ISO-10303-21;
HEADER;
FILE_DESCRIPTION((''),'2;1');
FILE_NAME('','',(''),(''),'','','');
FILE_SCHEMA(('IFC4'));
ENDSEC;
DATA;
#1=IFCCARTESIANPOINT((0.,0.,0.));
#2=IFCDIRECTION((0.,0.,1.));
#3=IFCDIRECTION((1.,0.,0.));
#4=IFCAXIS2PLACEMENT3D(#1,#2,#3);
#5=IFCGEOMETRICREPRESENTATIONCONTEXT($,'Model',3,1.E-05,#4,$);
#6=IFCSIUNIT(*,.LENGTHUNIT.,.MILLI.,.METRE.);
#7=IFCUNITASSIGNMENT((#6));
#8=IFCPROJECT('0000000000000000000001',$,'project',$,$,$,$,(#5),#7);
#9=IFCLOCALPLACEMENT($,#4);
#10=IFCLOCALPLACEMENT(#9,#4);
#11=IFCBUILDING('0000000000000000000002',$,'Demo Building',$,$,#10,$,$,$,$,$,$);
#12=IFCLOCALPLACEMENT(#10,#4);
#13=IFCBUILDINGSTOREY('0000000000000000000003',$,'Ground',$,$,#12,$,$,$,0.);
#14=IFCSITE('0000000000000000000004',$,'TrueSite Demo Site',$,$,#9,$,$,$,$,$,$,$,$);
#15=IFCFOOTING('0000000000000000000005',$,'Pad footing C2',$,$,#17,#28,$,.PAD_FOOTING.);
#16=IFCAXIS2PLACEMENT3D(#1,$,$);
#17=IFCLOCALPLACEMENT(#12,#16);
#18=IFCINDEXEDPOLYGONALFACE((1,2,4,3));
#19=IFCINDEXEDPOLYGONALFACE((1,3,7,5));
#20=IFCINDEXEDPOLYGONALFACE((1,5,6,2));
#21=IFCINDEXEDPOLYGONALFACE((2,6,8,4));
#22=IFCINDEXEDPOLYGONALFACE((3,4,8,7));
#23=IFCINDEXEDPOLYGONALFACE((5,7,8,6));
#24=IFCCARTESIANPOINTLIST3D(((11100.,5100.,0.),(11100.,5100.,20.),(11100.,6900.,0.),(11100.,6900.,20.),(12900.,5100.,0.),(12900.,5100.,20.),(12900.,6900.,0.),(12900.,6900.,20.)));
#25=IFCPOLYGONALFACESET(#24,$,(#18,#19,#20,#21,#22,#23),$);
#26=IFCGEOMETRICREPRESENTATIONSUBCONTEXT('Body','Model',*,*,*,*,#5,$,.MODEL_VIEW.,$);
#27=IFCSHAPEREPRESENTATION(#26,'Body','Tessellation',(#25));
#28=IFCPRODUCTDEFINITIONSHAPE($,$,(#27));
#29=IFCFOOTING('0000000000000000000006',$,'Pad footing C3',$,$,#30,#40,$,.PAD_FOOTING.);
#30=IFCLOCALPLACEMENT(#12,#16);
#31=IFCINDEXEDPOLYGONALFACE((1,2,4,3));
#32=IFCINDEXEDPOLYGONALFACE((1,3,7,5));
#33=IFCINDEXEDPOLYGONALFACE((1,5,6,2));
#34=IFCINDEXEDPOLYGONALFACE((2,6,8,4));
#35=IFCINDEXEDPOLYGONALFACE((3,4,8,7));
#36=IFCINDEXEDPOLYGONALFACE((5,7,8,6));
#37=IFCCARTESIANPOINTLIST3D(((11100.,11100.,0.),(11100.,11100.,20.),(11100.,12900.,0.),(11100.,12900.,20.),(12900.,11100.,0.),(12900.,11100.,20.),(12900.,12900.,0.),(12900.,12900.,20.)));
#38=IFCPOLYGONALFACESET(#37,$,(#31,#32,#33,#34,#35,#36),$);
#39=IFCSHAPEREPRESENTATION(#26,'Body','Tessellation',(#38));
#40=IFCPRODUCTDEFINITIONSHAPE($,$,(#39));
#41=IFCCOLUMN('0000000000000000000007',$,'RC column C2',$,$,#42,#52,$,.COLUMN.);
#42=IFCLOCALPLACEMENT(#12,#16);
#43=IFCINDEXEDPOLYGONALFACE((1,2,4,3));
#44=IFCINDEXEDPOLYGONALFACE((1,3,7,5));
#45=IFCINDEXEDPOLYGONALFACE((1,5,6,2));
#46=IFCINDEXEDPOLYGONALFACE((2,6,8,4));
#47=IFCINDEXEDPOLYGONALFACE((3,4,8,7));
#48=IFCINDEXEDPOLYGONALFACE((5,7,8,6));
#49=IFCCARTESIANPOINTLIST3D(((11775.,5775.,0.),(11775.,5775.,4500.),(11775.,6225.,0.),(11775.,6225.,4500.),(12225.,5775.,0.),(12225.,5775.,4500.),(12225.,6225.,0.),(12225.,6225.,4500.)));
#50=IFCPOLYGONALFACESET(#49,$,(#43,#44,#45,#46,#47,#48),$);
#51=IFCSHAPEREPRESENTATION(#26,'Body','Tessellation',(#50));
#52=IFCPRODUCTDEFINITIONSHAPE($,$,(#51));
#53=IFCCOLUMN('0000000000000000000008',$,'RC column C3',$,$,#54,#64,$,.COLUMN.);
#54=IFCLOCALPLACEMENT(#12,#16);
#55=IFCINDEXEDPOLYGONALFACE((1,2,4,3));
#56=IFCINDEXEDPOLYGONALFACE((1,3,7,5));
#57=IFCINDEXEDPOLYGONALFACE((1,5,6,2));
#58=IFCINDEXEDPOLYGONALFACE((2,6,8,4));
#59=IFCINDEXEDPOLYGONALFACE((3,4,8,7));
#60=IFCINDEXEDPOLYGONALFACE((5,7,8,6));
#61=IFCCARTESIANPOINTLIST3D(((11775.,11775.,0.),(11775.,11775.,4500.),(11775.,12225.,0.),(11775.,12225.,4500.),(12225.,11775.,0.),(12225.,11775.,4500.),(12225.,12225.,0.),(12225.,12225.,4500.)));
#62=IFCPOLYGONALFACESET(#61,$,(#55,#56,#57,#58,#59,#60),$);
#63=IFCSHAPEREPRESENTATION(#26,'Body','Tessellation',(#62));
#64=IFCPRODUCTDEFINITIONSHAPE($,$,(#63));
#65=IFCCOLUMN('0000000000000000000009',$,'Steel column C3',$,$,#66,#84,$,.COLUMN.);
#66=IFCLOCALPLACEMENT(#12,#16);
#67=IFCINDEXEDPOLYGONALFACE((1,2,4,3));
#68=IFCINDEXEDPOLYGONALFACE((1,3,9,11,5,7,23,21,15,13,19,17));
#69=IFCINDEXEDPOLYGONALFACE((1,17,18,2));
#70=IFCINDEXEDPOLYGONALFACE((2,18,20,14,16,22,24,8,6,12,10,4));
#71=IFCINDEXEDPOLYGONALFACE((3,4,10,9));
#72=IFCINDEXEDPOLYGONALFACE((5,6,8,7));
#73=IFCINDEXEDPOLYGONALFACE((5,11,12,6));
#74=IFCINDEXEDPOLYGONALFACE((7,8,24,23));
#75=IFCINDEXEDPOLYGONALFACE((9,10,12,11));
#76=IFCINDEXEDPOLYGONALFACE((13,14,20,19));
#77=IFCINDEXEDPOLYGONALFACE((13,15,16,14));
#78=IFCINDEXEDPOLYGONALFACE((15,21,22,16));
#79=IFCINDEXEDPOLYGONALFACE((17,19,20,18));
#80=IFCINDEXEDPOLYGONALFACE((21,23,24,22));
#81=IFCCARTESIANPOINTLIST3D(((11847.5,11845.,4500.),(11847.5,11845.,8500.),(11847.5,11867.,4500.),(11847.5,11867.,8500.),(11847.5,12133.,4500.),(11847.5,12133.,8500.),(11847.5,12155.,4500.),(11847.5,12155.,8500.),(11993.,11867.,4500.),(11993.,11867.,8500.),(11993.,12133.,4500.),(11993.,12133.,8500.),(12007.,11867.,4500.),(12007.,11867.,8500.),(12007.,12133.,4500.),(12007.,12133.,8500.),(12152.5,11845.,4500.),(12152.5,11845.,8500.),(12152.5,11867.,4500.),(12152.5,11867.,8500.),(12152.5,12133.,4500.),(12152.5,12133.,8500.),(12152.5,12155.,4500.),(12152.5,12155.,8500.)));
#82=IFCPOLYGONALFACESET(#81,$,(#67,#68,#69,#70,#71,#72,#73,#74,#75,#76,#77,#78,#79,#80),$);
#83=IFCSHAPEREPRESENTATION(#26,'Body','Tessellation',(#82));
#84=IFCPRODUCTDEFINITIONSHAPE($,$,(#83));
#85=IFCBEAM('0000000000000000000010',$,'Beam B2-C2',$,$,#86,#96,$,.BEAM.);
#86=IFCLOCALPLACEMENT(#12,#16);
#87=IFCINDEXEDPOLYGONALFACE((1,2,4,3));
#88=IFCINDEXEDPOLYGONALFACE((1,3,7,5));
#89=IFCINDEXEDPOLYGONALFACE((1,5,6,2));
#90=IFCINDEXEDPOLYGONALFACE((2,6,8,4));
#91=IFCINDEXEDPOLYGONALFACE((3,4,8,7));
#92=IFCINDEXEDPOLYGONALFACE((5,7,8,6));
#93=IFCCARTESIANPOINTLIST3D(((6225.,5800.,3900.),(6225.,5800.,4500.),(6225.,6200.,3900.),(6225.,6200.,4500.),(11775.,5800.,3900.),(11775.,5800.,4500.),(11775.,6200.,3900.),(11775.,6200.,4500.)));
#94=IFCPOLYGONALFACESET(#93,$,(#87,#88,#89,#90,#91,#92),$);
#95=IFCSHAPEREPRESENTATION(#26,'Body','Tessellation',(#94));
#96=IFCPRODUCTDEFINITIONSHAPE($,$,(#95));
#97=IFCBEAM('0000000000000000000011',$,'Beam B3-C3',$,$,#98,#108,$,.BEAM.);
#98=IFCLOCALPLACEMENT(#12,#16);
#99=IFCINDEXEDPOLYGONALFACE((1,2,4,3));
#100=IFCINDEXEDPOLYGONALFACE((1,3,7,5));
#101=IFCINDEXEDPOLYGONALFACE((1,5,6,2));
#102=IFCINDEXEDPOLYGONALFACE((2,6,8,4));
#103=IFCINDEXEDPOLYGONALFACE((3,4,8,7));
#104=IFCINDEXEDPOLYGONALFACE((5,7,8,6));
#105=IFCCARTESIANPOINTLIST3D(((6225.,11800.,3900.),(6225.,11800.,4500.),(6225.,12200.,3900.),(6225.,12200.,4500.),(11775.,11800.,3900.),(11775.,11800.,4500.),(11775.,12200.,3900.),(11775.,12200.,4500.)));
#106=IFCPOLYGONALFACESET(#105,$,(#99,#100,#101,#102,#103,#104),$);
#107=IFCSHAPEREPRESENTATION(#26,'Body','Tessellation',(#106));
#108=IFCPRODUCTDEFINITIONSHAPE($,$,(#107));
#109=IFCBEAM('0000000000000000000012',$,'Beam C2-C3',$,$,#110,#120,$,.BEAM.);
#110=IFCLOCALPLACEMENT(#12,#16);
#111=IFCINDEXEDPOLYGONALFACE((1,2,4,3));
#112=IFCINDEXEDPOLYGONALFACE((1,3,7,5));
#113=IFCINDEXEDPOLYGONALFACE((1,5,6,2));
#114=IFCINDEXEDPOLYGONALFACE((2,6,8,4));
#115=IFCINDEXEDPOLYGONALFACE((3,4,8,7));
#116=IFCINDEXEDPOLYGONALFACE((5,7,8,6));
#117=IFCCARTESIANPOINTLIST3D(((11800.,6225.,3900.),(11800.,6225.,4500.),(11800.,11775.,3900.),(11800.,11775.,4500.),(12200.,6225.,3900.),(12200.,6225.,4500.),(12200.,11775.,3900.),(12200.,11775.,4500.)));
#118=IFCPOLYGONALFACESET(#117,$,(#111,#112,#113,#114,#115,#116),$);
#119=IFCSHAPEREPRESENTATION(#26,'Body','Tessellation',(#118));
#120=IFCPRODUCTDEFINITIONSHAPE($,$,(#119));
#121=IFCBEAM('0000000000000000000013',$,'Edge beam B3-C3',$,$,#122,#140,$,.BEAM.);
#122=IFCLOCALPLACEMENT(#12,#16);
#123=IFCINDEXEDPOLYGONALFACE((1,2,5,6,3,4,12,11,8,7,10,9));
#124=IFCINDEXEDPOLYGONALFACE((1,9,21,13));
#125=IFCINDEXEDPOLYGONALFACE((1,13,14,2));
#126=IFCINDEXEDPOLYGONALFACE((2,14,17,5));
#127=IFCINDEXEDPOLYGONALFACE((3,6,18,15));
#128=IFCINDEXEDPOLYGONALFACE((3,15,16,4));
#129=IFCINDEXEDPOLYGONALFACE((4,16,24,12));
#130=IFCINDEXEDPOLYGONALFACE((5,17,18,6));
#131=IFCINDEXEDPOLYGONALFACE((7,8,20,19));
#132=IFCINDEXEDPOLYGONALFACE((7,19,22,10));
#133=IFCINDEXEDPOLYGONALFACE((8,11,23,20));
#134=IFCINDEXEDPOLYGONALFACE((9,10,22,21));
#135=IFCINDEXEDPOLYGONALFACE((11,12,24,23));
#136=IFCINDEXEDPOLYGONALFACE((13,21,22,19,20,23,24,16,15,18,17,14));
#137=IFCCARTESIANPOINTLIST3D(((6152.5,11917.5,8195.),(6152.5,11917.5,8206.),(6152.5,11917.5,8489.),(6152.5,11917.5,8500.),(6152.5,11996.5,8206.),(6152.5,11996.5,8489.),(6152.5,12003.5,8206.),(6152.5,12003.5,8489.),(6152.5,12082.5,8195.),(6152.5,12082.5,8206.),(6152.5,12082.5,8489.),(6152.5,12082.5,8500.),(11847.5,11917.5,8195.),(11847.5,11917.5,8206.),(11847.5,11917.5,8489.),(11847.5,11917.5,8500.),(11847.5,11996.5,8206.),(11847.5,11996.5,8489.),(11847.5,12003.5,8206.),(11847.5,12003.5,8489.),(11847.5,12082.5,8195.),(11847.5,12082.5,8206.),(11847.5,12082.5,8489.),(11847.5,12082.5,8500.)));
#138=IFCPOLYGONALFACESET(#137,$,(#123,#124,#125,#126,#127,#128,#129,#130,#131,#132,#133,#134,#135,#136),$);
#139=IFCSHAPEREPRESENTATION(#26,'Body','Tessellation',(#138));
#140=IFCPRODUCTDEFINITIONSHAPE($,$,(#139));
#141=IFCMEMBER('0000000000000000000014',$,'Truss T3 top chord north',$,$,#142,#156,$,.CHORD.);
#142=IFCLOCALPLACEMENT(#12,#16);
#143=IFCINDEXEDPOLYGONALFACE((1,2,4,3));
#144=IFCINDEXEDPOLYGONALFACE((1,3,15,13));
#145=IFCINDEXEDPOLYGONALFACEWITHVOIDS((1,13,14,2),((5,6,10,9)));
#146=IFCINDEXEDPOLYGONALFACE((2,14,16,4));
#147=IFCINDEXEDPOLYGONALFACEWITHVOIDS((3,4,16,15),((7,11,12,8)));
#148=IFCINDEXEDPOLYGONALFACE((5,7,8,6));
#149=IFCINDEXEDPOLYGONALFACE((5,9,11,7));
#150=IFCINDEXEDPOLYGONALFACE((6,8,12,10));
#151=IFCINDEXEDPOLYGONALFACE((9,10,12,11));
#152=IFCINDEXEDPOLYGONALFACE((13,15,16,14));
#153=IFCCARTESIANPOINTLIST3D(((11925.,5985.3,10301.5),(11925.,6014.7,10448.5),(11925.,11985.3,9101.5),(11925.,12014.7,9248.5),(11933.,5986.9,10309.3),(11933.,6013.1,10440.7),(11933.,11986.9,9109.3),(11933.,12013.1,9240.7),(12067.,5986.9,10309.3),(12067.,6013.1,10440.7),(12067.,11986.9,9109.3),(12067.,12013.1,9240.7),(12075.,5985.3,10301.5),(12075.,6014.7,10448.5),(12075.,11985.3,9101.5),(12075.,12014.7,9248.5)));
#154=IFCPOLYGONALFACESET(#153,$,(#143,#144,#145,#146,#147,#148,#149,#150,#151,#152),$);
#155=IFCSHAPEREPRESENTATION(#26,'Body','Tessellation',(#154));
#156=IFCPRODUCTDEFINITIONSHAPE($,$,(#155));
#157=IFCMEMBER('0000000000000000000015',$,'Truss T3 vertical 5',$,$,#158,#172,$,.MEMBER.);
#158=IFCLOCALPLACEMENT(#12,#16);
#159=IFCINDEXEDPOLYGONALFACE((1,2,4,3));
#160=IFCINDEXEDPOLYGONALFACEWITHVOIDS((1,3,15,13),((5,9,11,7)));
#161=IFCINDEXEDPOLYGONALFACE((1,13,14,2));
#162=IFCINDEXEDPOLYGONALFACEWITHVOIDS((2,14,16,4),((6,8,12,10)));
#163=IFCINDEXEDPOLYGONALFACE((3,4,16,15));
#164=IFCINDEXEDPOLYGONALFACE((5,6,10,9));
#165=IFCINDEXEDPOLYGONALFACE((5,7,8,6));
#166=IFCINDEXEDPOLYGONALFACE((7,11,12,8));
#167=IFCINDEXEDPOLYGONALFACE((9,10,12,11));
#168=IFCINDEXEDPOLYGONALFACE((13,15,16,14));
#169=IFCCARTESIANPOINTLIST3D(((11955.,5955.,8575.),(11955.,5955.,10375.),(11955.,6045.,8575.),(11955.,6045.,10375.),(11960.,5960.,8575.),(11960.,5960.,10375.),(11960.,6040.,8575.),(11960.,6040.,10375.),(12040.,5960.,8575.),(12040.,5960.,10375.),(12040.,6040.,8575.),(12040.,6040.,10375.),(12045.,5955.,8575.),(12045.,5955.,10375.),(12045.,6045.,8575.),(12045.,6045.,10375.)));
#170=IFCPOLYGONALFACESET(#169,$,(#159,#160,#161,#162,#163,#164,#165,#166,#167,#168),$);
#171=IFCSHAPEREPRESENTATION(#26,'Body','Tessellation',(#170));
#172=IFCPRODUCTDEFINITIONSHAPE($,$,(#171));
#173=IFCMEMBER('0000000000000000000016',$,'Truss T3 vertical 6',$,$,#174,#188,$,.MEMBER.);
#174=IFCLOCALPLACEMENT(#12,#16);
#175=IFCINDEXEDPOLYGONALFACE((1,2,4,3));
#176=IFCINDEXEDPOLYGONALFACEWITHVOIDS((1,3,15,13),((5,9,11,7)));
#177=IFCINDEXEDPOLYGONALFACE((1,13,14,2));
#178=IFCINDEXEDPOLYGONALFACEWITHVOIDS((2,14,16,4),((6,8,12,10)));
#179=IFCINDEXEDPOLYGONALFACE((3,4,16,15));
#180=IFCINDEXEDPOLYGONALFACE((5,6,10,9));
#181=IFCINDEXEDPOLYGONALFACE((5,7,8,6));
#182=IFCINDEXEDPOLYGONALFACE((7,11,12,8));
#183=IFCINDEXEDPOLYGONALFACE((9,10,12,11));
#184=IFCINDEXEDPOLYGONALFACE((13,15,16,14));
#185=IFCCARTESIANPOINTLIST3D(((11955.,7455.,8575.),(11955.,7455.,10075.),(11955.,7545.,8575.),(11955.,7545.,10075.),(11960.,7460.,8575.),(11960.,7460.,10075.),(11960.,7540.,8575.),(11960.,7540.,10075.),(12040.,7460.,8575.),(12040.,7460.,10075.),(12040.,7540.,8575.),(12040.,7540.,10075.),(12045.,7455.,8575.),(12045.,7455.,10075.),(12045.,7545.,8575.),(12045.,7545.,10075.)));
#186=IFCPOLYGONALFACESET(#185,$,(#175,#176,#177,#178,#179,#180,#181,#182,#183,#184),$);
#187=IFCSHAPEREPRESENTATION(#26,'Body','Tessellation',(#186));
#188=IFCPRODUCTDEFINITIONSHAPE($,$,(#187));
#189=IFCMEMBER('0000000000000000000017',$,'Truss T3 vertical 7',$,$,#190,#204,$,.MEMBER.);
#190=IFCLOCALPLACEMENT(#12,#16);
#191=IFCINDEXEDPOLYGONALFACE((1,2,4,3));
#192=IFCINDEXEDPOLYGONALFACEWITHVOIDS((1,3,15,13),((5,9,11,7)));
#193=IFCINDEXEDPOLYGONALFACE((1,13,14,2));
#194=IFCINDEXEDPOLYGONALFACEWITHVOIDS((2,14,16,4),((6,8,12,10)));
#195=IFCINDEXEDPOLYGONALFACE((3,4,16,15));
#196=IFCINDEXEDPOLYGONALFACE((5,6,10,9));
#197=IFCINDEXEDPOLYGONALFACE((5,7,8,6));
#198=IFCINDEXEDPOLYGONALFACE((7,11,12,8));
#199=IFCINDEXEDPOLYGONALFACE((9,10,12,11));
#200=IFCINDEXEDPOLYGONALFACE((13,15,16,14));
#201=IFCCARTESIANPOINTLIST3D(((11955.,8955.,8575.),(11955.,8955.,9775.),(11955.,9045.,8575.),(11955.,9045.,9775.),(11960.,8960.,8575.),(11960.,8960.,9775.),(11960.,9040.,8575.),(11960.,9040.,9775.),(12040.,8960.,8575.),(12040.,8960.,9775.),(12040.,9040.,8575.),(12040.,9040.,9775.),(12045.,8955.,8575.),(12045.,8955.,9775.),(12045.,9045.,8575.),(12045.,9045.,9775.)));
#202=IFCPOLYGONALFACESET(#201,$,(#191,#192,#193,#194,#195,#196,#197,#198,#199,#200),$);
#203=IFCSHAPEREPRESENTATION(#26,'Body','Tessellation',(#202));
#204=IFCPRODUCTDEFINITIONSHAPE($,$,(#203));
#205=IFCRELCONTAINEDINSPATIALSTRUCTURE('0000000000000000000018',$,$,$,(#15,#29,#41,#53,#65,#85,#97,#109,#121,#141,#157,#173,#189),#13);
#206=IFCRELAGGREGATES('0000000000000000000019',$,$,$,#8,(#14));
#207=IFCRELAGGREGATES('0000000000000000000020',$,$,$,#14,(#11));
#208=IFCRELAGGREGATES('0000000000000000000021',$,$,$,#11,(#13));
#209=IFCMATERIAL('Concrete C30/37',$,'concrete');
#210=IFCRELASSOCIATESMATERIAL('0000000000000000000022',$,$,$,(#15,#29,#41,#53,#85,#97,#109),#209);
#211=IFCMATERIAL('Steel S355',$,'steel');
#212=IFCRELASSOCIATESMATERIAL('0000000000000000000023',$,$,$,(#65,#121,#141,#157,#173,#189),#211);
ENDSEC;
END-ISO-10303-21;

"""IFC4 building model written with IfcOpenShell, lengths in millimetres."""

from ifc_helpers import new_model, si_unit, frame, origin_with_axes, place, context, subcontext, project, spatial, rectangle, hollow_rectangle, i_section, extrude, material, element, save


model = new_model("IFC4")

# Units and contexts
model_context = context("Model", 3, precision=1e-05, world=origin_with_axes())
body_context = subcontext(model_context, "Body", "Model", "MODEL_VIEW")
ifc_project = project(units=[si_unit("LENGTHUNIT", "METRE", prefix="MILLI")], contexts=[model_context])

# Site, building, storey
site_placement = place(None, origin_with_axes())
site = spatial("IfcSite", under=ifc_project, at=site_placement, Name="TrueSite Demo Site")
building_placement = place(site_placement, origin_with_axes())
building = spatial("IfcBuilding", under=site, at=building_placement, Name="Demo Building")
storey_placement = place(building_placement, origin_with_axes())
storey = spatial("IfcBuildingStorey", under=building, at=storey_placement, Name="Ground", Elevation=0.0)

# Footings
ifc_material_1 = material(Name="Concrete C30/37", Category="concrete")
for number, where, z_axis, x_axis, name in (
    (1, (12000.0, 6000.0, 0.0), (0.0, 0.0, 1.0), (1.0, 0.0, 0.0), "Pad footing C2"),
    (2, (12000.0, 12000.0, 0.0), (0.0, 0.0, 1.0), (1.0, 0.0, 0.0), "Pad footing C3"),
):
    element("IfcFooting", number, at=place(storey_placement, frame(where, z_axis=z_axis, x_axis=x_axis)), inside=storey, material=ifc_material_1, Name=name, PredefinedType="PAD_FOOTING", context=body_context, shape_type="SweptSolid", body=[
        extrude(rectangle(XDim=1800.0, YDim=1800.0), origin_with_axes(), (0.0, 0.0, 1.0), 20.0),
    ])

# Columns
for number, where, z_axis, x_axis, name in (
    (3, (12000.0, 6000.0, 0.0), (0.0, 0.0, 1.0), (1.0, 0.0, 0.0), "RC column C2"),
    (4, (12000.0, 12000.0, 0.0), (0.0, 0.0, 1.0), (1.0, 0.0, 0.0), "RC column C3"),
):
    element("IfcColumn", number, at=place(storey_placement, frame(where, z_axis=z_axis, x_axis=x_axis)), inside=storey, material=ifc_material_1, Name=name, PredefinedType="COLUMN", context=body_context, shape_type="SweptSolid", body=[
        extrude(rectangle(XDim=450.0, YDim=450.0), origin_with_axes(), (0.0, 0.0, 1.0), 4500.0),
    ])
ifc_material_2 = material(Name="Steel S355", Category="steel")
column_placement = place(storey_placement, frame((12000.0, 12000.0, 4500.0), z_axis=(0.0, 0.0, 1.0), x_axis=(1.0, 0.0, 0.0)))
element("IfcColumn", 5, at=column_placement, inside=storey, material=ifc_material_2, Name="Steel column C3", PredefinedType="COLUMN", context=body_context, shape_type="SweptSolid", body=[
    extrude(i_section(OverallWidth=305.0, OverallDepth=310.0, WebThickness=14.0, FlangeThickness=22.0), origin_with_axes(), (0.0, 0.0, 1.0), 4000.0),
])

# Beams
for number, where, z_axis, x_axis, name in (
    (6, (6225.0, 6000.0, 4200.0), (1.0, 0.0, 0.0), (0.0, 1.0, 0.0), "Beam B2-C2"),
    (7, (6225.0, 12000.0, 4200.0), (1.0, 0.0, 0.0), (0.0, 1.0, 0.0), "Beam B3-C3"),
    (8, (12000.0, 6225.0, 4200.0), (0.0, 1.0, 0.0), (-1.0, 0.0, 0.0), "Beam C2-C3"),
):
    element("IfcBeam", number, at=place(storey_placement, frame(where, z_axis=z_axis, x_axis=x_axis)), inside=storey, material=ifc_material_1, Name=name, PredefinedType="BEAM", context=body_context, shape_type="SweptSolid", body=[
        extrude(rectangle(XDim=400.0, YDim=600.0), origin_with_axes(), (0.0, 0.0, 1.0), 5550.0),
    ])
beam_placement = place(storey_placement, frame((6152.5, 12000.0, 8347.5), z_axis=(1.0, 0.0, 0.0), x_axis=(0.0, 1.0, 0.0)))
element("IfcBeam", 9, at=beam_placement, inside=storey, material=ifc_material_2, Name="Edge beam B3-C3", PredefinedType="BEAM", context=body_context, shape_type="SweptSolid", body=[
    extrude(i_section(OverallWidth=165.0, OverallDepth=305.0, WebThickness=7.0, FlangeThickness=11.0), origin_with_axes(), (0.0, 0.0, 1.0), 5695.0),
])

# Members
member_1_placement = place(storey_placement, frame((12000.0, 6000.0, 10375.0), z_axis=(0.0, 0.980581, -0.196116), x_axis=(-1.0, 0.0, 0.0)))
element("IfcMember", 10, at=member_1_placement, inside=storey, material=ifc_material_2, Name="Truss T3 top chord north", PredefinedType="CHORD", context=body_context, shape_type="SweptSolid", body=[
    extrude(hollow_rectangle(XDim=150.0, YDim=150.0, WallThickness=8.0), origin_with_axes(), (0.0, 0.0, 1.0), 6118.8),
])
member_2_placement = place(storey_placement, frame((12000.0, 6000.0, 8575.0), z_axis=(0.0, 0.0, 1.0), x_axis=(1.0, 0.0, 0.0)))
element("IfcMember", 11, at=member_2_placement, inside=storey, material=ifc_material_2, Name="Truss T3 vertical 5", PredefinedType="MEMBER", context=body_context, shape_type="SweptSolid", body=[
    extrude(hollow_rectangle(XDim=90.0, YDim=90.0, WallThickness=5.0), origin_with_axes(), (0.0, 0.0, 1.0), 1800.0),
])
member_3_placement = place(storey_placement, frame((12000.0, 7500.0, 8575.0), z_axis=(0.0, 0.0, 1.0), x_axis=(1.0, 0.0, 0.0)))
element("IfcMember", 12, at=member_3_placement, inside=storey, material=ifc_material_2, Name="Truss T3 vertical 6", PredefinedType="MEMBER", context=body_context, shape_type="SweptSolid", body=[
    extrude(hollow_rectangle(XDim=90.0, YDim=90.0, WallThickness=5.0), origin_with_axes(), (0.0, 0.0, 1.0), 1500.0),
])
member_4_placement = place(storey_placement, frame((12000.0, 9000.0, 8575.0), z_axis=(0.0, 0.0, 1.0), x_axis=(1.0, 0.0, 0.0)))
element("IfcMember", 13, at=member_4_placement, inside=storey, material=ifc_material_2, Name="Truss T3 vertical 7", PredefinedType="MEMBER", context=body_context, shape_type="SweptSolid", body=[
    extrude(hollow_rectangle(XDim=90.0, YDim=90.0, WallThickness=5.0), origin_with_axes(), (0.0, 0.0, 1.0), 1200.0),
])

save(model, "model.ifc")
